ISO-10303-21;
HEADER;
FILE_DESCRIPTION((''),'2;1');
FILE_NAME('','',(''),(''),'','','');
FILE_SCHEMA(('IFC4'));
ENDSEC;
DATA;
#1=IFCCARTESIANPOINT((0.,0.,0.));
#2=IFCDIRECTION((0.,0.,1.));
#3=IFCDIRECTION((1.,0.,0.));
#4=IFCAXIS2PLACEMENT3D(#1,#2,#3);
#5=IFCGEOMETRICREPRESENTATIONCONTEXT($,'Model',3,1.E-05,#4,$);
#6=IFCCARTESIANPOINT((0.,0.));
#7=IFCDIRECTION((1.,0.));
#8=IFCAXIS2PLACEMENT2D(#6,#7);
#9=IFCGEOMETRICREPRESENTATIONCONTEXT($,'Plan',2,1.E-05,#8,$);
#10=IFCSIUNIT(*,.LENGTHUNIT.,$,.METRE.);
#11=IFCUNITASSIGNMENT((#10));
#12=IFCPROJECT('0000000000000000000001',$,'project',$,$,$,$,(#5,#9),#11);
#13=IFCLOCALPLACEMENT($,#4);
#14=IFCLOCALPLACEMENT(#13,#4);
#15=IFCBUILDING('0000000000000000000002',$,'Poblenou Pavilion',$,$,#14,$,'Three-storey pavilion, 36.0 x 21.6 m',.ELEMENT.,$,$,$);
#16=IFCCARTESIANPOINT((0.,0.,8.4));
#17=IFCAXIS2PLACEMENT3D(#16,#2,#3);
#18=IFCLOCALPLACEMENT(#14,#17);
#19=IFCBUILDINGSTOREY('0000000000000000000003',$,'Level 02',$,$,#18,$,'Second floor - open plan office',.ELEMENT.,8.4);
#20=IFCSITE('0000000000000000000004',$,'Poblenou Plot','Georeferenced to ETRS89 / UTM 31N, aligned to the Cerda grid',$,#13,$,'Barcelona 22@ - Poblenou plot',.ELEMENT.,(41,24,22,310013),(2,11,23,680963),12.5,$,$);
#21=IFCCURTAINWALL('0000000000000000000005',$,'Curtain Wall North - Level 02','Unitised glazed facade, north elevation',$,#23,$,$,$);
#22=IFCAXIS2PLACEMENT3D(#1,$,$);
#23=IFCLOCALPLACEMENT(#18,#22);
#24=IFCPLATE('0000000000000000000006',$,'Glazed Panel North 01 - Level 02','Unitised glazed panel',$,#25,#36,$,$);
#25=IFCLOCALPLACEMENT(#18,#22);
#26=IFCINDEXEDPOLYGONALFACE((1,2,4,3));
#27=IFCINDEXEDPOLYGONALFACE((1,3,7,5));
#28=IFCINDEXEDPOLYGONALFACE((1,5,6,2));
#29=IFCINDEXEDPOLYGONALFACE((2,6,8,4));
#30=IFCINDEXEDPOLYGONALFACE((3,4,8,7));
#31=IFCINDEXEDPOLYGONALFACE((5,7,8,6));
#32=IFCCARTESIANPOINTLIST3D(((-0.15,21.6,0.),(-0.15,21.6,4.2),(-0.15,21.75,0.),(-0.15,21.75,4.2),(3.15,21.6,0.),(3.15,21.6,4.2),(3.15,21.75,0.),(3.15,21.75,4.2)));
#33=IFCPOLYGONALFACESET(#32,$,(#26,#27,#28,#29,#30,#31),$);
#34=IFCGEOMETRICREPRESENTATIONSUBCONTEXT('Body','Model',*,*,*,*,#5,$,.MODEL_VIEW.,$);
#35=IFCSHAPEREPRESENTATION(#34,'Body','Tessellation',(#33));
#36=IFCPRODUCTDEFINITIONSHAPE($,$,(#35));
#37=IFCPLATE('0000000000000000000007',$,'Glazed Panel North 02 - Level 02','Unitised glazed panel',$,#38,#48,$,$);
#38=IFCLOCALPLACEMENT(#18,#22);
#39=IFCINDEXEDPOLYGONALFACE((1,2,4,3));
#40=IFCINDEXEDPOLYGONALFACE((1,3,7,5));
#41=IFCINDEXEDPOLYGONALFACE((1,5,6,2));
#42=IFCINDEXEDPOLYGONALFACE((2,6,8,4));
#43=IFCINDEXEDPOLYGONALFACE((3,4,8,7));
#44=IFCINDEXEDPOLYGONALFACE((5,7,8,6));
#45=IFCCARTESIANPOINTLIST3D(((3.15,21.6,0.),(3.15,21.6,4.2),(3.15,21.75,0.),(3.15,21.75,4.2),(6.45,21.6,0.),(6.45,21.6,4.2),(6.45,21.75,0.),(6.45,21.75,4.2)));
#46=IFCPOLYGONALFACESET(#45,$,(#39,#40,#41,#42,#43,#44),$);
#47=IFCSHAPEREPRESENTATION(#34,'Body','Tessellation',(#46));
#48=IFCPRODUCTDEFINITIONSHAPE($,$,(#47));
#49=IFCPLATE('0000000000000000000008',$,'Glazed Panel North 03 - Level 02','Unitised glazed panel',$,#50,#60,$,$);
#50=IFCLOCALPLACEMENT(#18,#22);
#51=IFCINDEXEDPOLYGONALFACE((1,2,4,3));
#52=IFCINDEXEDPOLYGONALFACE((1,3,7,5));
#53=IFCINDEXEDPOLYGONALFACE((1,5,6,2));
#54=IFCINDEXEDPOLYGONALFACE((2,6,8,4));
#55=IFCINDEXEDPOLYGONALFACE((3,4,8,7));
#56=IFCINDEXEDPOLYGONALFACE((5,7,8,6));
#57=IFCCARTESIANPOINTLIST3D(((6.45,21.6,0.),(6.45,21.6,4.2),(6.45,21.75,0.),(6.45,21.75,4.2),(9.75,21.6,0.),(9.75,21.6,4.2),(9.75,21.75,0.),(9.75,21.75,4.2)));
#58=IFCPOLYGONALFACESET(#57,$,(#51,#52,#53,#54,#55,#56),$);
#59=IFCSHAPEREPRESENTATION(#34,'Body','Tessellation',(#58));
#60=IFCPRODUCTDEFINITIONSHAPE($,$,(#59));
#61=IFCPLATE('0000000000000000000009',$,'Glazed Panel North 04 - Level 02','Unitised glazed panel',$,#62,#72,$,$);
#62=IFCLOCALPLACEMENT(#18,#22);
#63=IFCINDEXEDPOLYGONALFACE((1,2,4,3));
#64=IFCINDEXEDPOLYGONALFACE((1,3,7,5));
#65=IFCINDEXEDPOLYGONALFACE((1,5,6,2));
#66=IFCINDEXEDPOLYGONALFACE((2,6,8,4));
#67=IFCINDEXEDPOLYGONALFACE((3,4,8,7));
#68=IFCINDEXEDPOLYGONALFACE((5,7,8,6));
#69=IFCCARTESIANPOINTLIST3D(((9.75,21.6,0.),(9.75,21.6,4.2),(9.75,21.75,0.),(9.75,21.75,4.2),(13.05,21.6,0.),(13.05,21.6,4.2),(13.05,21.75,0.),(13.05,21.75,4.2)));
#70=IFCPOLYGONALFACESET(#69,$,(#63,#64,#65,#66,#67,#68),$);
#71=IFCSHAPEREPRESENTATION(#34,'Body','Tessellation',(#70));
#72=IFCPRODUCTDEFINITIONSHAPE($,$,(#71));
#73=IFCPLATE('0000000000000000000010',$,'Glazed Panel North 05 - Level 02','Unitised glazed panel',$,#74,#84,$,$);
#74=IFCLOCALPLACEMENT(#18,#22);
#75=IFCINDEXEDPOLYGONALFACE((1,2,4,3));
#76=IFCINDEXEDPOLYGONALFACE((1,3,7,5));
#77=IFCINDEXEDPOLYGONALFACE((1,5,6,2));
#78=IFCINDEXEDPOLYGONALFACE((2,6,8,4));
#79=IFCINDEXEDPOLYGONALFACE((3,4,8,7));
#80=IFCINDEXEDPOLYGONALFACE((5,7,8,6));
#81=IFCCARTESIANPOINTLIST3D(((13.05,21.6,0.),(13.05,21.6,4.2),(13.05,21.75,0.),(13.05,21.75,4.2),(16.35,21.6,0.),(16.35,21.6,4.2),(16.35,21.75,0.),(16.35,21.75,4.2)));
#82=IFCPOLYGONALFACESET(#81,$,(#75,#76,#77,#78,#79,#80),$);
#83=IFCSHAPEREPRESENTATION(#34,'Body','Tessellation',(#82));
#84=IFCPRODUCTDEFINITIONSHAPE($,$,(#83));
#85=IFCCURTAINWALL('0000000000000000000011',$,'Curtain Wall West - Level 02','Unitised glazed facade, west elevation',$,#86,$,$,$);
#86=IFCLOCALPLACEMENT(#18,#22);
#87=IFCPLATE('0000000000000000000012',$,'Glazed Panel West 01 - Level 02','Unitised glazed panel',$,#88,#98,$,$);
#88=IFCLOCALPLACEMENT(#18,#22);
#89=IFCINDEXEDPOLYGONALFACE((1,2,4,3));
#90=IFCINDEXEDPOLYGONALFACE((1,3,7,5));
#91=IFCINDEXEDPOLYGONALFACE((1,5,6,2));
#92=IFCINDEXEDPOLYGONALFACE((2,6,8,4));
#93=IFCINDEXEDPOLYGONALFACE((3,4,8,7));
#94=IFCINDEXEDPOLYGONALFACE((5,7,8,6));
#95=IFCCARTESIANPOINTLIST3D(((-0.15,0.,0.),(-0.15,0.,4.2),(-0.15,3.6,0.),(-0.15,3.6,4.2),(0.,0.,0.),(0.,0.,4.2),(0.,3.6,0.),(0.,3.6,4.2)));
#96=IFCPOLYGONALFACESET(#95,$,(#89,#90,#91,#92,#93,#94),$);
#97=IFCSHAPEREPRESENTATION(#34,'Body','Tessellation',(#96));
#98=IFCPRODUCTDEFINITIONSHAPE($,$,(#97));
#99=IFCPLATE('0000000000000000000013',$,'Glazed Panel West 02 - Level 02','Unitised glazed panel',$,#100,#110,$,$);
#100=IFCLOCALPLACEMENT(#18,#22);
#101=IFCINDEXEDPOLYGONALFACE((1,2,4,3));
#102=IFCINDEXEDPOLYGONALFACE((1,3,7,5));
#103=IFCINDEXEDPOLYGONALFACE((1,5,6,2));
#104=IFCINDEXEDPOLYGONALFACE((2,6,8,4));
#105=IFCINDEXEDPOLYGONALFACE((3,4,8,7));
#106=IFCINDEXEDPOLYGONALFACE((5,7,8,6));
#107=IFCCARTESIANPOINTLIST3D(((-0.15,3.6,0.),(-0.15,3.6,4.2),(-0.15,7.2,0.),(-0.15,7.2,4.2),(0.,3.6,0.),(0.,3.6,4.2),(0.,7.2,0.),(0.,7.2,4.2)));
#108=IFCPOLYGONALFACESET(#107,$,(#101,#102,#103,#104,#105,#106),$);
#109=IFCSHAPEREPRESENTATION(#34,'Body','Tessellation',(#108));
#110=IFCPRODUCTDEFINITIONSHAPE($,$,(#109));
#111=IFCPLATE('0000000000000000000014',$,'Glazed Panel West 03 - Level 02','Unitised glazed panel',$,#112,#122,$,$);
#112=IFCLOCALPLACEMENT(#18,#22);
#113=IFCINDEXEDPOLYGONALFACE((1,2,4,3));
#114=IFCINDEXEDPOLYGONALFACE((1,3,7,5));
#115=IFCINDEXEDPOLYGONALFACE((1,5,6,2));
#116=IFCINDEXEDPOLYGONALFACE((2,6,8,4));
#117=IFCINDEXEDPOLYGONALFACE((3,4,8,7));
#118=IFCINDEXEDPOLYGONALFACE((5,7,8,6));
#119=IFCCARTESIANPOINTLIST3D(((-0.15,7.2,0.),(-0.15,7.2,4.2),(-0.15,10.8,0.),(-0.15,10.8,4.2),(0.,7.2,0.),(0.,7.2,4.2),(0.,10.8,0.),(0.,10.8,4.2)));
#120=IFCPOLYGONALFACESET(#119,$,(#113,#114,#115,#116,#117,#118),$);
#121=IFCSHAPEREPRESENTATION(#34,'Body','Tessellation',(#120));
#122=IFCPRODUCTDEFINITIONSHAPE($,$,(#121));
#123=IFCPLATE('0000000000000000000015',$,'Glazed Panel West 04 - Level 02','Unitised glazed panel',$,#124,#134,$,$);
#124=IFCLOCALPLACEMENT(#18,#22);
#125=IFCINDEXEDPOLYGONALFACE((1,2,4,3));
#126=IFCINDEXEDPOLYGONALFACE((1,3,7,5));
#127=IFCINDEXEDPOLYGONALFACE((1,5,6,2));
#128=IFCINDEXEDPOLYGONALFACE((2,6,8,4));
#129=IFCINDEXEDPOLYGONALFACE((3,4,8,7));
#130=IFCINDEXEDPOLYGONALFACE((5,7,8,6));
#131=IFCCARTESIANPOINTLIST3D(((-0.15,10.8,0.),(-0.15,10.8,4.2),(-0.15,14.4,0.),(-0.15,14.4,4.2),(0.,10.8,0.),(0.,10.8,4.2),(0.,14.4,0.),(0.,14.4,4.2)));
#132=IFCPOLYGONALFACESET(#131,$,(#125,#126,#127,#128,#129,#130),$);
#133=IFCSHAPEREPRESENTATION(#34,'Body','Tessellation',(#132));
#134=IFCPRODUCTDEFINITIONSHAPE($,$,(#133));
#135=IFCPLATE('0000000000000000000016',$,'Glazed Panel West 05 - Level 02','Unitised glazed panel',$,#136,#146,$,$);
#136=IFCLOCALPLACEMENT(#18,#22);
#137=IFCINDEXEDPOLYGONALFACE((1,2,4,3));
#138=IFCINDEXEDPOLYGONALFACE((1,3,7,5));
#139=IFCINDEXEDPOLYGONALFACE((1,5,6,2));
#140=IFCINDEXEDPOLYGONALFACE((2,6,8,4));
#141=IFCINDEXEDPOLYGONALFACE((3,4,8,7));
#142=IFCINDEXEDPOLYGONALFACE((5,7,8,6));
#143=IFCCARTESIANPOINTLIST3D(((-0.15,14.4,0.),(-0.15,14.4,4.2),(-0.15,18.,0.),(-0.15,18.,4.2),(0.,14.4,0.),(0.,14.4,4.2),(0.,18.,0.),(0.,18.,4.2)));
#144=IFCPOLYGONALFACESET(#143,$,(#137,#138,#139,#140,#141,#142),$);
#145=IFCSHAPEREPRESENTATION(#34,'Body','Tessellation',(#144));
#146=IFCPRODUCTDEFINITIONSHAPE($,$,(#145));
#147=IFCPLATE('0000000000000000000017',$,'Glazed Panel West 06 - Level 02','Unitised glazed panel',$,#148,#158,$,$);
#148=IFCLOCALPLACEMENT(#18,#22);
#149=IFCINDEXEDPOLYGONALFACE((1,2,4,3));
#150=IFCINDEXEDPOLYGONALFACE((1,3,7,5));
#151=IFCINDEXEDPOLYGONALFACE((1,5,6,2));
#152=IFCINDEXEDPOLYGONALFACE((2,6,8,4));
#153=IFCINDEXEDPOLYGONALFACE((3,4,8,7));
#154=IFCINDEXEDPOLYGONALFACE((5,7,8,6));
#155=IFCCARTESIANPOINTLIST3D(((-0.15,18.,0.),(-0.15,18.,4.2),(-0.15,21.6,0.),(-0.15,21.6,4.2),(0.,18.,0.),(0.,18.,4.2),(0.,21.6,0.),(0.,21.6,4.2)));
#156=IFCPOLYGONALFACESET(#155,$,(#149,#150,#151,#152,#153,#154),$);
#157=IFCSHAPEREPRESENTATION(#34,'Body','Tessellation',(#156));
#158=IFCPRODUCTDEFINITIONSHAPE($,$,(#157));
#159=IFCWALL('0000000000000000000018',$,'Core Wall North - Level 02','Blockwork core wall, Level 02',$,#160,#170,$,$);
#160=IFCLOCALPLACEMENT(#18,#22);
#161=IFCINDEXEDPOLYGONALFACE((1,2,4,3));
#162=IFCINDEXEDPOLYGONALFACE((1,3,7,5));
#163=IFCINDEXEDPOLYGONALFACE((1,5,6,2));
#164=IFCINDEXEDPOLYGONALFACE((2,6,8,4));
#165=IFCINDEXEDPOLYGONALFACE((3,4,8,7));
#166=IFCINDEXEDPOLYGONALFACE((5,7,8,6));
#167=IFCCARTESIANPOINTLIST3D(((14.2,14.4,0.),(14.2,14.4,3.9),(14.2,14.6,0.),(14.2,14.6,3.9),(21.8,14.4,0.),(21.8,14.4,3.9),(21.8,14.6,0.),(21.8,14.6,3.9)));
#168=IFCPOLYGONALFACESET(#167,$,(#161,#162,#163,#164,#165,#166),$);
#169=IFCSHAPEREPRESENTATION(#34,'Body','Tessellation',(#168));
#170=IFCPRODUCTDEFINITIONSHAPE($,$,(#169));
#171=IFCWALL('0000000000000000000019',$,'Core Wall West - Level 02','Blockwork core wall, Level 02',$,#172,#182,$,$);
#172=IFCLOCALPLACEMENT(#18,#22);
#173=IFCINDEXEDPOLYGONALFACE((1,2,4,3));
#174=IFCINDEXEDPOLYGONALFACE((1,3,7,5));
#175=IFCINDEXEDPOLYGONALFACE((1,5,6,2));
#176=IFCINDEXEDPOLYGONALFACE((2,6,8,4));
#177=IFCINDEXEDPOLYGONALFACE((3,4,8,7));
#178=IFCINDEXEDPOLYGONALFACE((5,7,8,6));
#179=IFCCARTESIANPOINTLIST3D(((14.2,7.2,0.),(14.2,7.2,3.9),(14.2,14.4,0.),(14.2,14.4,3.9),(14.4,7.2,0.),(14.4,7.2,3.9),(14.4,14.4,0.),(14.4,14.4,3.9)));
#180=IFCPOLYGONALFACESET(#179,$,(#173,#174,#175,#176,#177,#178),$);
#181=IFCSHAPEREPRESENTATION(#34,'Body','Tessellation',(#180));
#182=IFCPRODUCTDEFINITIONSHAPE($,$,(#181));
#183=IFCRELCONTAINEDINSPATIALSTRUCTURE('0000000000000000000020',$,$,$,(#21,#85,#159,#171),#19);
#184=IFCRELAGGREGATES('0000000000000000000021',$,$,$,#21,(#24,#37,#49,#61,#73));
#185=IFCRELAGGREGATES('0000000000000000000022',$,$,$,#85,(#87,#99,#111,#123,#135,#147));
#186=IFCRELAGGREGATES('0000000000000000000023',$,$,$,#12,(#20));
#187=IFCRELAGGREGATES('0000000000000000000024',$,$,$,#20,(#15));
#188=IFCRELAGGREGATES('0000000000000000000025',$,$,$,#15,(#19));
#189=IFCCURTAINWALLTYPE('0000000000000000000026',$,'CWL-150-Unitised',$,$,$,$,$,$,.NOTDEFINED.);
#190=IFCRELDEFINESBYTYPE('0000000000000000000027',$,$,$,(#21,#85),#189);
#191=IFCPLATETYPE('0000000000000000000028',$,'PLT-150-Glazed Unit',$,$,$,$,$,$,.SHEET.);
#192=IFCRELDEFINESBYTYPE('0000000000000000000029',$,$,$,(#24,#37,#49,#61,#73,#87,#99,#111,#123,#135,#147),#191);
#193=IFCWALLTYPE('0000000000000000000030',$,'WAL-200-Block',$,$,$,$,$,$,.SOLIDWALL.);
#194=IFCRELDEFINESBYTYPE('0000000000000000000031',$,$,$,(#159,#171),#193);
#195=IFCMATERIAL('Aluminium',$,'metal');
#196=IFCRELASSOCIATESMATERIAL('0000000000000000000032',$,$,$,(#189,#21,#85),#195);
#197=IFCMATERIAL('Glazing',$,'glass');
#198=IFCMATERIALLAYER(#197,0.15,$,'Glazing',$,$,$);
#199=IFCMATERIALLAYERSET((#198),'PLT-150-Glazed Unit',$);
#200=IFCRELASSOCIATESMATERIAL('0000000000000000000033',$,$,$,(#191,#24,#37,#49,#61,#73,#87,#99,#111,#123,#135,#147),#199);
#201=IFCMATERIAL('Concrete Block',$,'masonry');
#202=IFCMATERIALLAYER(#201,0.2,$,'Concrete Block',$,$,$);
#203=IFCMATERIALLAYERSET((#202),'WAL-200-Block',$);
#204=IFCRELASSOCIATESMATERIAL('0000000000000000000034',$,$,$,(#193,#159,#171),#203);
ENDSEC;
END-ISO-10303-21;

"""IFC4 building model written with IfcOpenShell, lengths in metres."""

from ifc_helpers import new_model, si_unit, frame, origin_with_axes, origin_2d_with_axis, place, context, subcontext, project, spatial, line, indexed_curve, outline, extrude, material, layer, layer_set, layer_usage, type_object, element, aggregate, save


model = new_model("IFC4")

# Units and contexts
model_context = context("Model", 3, precision=1e-05, world=origin_with_axes())
plan_context = context("Plan", 2, precision=1e-05, world=origin_2d_with_axis())
body_context = subcontext(model_context, "Body", "Model", "MODEL_VIEW")
ifc_project = project(units=[si_unit("LENGTHUNIT", "METRE")], contexts=[model_context, plan_context])

# Site, building, storey
site_placement = place(None, origin_with_axes())
site = spatial("IfcSite", under=ifc_project, at=site_placement, Name="Poblenou Plot", Description="Georeferenced to ETRS89 / UTM 31N, aligned to the Cerda grid", LongName="Barcelona 22@ - Poblenou plot", CompositionType="ELEMENT", RefLatitude=(41, 24, 22, 310013), RefLongitude=(2, 11, 23, 680963), RefElevation=12.5)
building_placement = place(site_placement, origin_with_axes())
building = spatial("IfcBuilding", under=site, at=building_placement, Name="Poblenou Pavilion", LongName="Three-storey pavilion, 36.0 x 21.6 m", CompositionType="ELEMENT")
storey_placement = place(building_placement, frame((0.0, 0.0, 8.4), z_axis=(0.0, 0.0, 1.0), x_axis=(1.0, 0.0, 0.0)))
storey = spatial("IfcBuildingStorey", under=building, at=storey_placement, Name="Level 02", LongName="Second floor - open plan office", CompositionType="ELEMENT", Elevation=8.4)

# Curtain walls, plates
ifc_material_1 = material(Name="Aluminium", Category="metal")
curtain_wall_type = type_object("IfcCurtainWallType", Name="CWL-150-Unitised", PredefinedType="NOTDEFINED", material=ifc_material_1)
ifc_material_2 = material(Name="Glazing", Category="glass")
ifc_layer_1 = layer(ifc_material_2, 0.15, Name="Glazing")
ifc_layer_set_1 = layer_set([ifc_layer_1], Name="PLT-150-Glazed Unit")
plate_type = type_object("IfcPlateType", Name="PLT-150-Glazed Unit", PredefinedType="SHEET", material=ifc_layer_set_1)
curtain_wall_1_placement = place(storey_placement, frame((-0.15, 21.6, 0.0), z_axis=(0.0, 0.0, 1.0), x_axis=(1.0, 0.0, 0.0)))
curtain_wall_1 = element("IfcCurtainWall", 1, at=curtain_wall_1_placement, inside=storey, type_object=curtain_wall_type, material=ifc_material_1, Name="Curtain Wall North - Level 02", Description="Unitised glazed facade, north elevation")
ifc_layer_usage_1 = layer_usage(ifc_layer_set_1, "AXIS2", "POSITIVE", 0.0)
plate_1_placement = place(curtain_wall_1_placement, origin_with_axes())
plate_1 = element("IfcPlate", 2, at=plate_1_placement, type_object=plate_type, material=ifc_layer_usage_1, Name="Glazed Panel North 01 - Level 02", Description="Unitised glazed panel", context=body_context, shape_type="SweptSolid", body=[
    extrude(outline(indexed_curve([(0.0, 0.0), (3.3, 0.0), (3.3, 0.15), (0.0, 0.15)], segments=[line(1, 2, 3, 4, 1)])), origin_with_axes(), (0.0, 0.0, 1.0), 4.2),
])
ifc_layer_usage_2 = layer_usage(ifc_layer_set_1, "AXIS2", "POSITIVE", 0.0)
plate_2_placement = place(curtain_wall_1_placement, frame((3.3, 0.0, 0.0), z_axis=(0.0, 0.0, 1.0), x_axis=(1.0, 0.0, 0.0)))
plate_2 = element("IfcPlate", 3, at=plate_2_placement, type_object=plate_type, material=ifc_layer_usage_2, Name="Glazed Panel North 02 - Level 02", Description="Unitised glazed panel", context=body_context, shape_type="SweptSolid", body=[
    extrude(outline(indexed_curve([(0.0, 0.0), (3.3, 0.0), (3.3, 0.15), (0.0, 0.15)], segments=[line(1, 2, 3, 4, 1)])), origin_with_axes(), (0.0, 0.0, 1.0), 4.2),
])
ifc_layer_usage_3 = layer_usage(ifc_layer_set_1, "AXIS2", "POSITIVE", 0.0)
plate_3_placement = place(curtain_wall_1_placement, frame((6.6, 0.0, 0.0), z_axis=(0.0, 0.0, 1.0), x_axis=(1.0, 0.0, 0.0)))
plate_3 = element("IfcPlate", 4, at=plate_3_placement, type_object=plate_type, material=ifc_layer_usage_3, Name="Glazed Panel North 03 - Level 02", Description="Unitised glazed panel", context=body_context, shape_type="SweptSolid", body=[
    extrude(outline(indexed_curve([(0.0, 0.0), (3.3, 0.0), (3.3, 0.15), (0.0, 0.15)], segments=[line(1, 2, 3, 4, 1)])), origin_with_axes(), (0.0, 0.0, 1.0), 4.2),
])
ifc_layer_usage_4 = layer_usage(ifc_layer_set_1, "AXIS2", "POSITIVE", 0.0)
plate_4_placement = place(curtain_wall_1_placement, frame((9.9, 0.0, 0.0), z_axis=(0.0, 0.0, 1.0), x_axis=(1.0, 0.0, 0.0)))
plate_4 = element("IfcPlate", 5, at=plate_4_placement, type_object=plate_type, material=ifc_layer_usage_4, Name="Glazed Panel North 04 - Level 02", Description="Unitised glazed panel", context=body_context, shape_type="SweptSolid", body=[
    extrude(outline(indexed_curve([(0.0, 0.0), (3.3, 0.0), (3.3, 0.15), (0.0, 0.15)], segments=[line(1, 2, 3, 4, 1)])), origin_with_axes(), (0.0, 0.0, 1.0), 4.2),
])
ifc_layer_usage_5 = layer_usage(ifc_layer_set_1, "AXIS2", "POSITIVE", 0.0)
plate_5_placement = place(curtain_wall_1_placement, frame((13.2, 0.0, 0.0), z_axis=(0.0, 0.0, 1.0), x_axis=(1.0, 0.0, 0.0)))
plate_5 = element("IfcPlate", 6, at=plate_5_placement, type_object=plate_type, material=ifc_layer_usage_5, Name="Glazed Panel North 05 - Level 02", Description="Unitised glazed panel", context=body_context, shape_type="SweptSolid", body=[
    extrude(outline(indexed_curve([(0.0, 0.0), (3.3, 0.0), (3.3, 0.15), (0.0, 0.15)], segments=[line(1, 2, 3, 4, 1)])), origin_with_axes(), (0.0, 0.0, 1.0), 4.2),
])
aggregate(curtain_wall_1, [plate_1, plate_2, plate_3, plate_4, plate_5])
curtain_wall_2_placement = place(storey_placement, frame((0.0, 0.0, 0.0), z_axis=(0.0, 0.0, 1.0), x_axis=(0.0, 1.0, 0.0)))
curtain_wall_2 = element("IfcCurtainWall", 7, at=curtain_wall_2_placement, inside=storey, type_object=curtain_wall_type, material=ifc_material_1, Name="Curtain Wall West - Level 02", Description="Unitised glazed facade, west elevation")
ifc_layer_usage_6 = layer_usage(ifc_layer_set_1, "AXIS2", "POSITIVE", 0.0)
plate_6_placement = place(curtain_wall_2_placement, origin_with_axes())
plate_6 = element("IfcPlate", 8, at=plate_6_placement, type_object=plate_type, material=ifc_layer_usage_6, Name="Glazed Panel West 01 - Level 02", Description="Unitised glazed panel", context=body_context, shape_type="SweptSolid", body=[
    extrude(outline(indexed_curve([(0.0, 0.0), (3.6, 0.0), (3.6, 0.15), (0.0, 0.15)], segments=[line(1, 2, 3, 4, 1)])), origin_with_axes(), (0.0, 0.0, 1.0), 4.2),
])
ifc_layer_usage_7 = layer_usage(ifc_layer_set_1, "AXIS2", "POSITIVE", 0.0)
plate_7_placement = place(curtain_wall_2_placement, frame((3.6, 0.0, 0.0), z_axis=(0.0, 0.0, 1.0), x_axis=(1.0, 0.0, 0.0)))
plate_7 = element("IfcPlate", 9, at=plate_7_placement, type_object=plate_type, material=ifc_layer_usage_7, Name="Glazed Panel West 02 - Level 02", Description="Unitised glazed panel", context=body_context, shape_type="SweptSolid", body=[
    extrude(outline(indexed_curve([(0.0, 0.0), (3.6, 0.0), (3.6, 0.15), (0.0, 0.15)], segments=[line(1, 2, 3, 4, 1)])), origin_with_axes(), (0.0, 0.0, 1.0), 4.2),
])
ifc_layer_usage_8 = layer_usage(ifc_layer_set_1, "AXIS2", "POSITIVE", 0.0)
plate_8_placement = place(curtain_wall_2_placement, frame((7.2, 0.0, 0.0), z_axis=(0.0, 0.0, 1.0), x_axis=(1.0, 0.0, 0.0)))
plate_8 = element("IfcPlate", 10, at=plate_8_placement, type_object=plate_type, material=ifc_layer_usage_8, Name="Glazed Panel West 03 - Level 02", Description="Unitised glazed panel", context=body_context, shape_type="SweptSolid", body=[
    extrude(outline(indexed_curve([(0.0, 0.0), (3.6, 0.0), (3.6, 0.15), (0.0, 0.15)], segments=[line(1, 2, 3, 4, 1)])), origin_with_axes(), (0.0, 0.0, 1.0), 4.2),
])
ifc_layer_usage_9 = layer_usage(ifc_layer_set_1, "AXIS2", "POSITIVE", 0.0)
plate_9_placement = place(curtain_wall_2_placement, frame((10.8, 0.0, 0.0), z_axis=(0.0, 0.0, 1.0), x_axis=(1.0, 0.0, 0.0)))
plate_9 = element("IfcPlate", 11, at=plate_9_placement, type_object=plate_type, material=ifc_layer_usage_9, Name="Glazed Panel West 04 - Level 02", Description="Unitised glazed panel", context=body_context, shape_type="SweptSolid", body=[
    extrude(outline(indexed_curve([(0.0, 0.0), (3.6, 0.0), (3.6, 0.15), (0.0, 0.15)], segments=[line(1, 2, 3, 4, 1)])), origin_with_axes(), (0.0, 0.0, 1.0), 4.2),
])
ifc_layer_usage_10 = layer_usage(ifc_layer_set_1, "AXIS2", "POSITIVE", 0.0)
plate_10_placement = place(curtain_wall_2_placement, frame((14.4, 0.0, 0.0), z_axis=(0.0, 0.0, 1.0), x_axis=(1.0, 0.0, 0.0)))
plate_10 = element("IfcPlate", 12, at=plate_10_placement, type_object=plate_type, material=ifc_layer_usage_10, Name="Glazed Panel West 05 - Level 02", Description="Unitised glazed panel", context=body_context, shape_type="SweptSolid", body=[
    extrude(outline(indexed_curve([(0.0, 0.0), (3.6, 0.0), (3.6, 0.15), (0.0, 0.15)], segments=[line(1, 2, 3, 4, 1)])), origin_with_axes(), (0.0, 0.0, 1.0), 4.2),
])
ifc_layer_usage_11 = layer_usage(ifc_layer_set_1, "AXIS2", "POSITIVE", 0.0)
plate_11_placement = place(curtain_wall_2_placement, frame((18.0, 0.0, 0.0), z_axis=(0.0, 0.0, 1.0), x_axis=(1.0, 0.0, 0.0)))
plate_11 = element("IfcPlate", 13, at=plate_11_placement, type_object=plate_type, material=ifc_layer_usage_11, Name="Glazed Panel West 06 - Level 02", Description="Unitised glazed panel", context=body_context, shape_type="SweptSolid", body=[
    extrude(outline(indexed_curve([(0.0, 0.0), (3.6, 0.0), (3.6, 0.15), (0.0, 0.15)], segments=[line(1, 2, 3, 4, 1)])), origin_with_axes(), (0.0, 0.0, 1.0), 4.2),
])
aggregate(curtain_wall_2, [plate_6, plate_7, plate_8, plate_9, plate_10, plate_11])

# Walls
ifc_material_3 = material(Name="Concrete Block", Category="masonry")
ifc_layer_2 = layer(ifc_material_3, 0.2, Name="Concrete Block")
ifc_layer_set_2 = layer_set([ifc_layer_2], Name="WAL-200-Block")
ifc_layer_usage_12 = layer_usage(ifc_layer_set_2, "AXIS2", "POSITIVE", 0.0)
wall_type = type_object("IfcWallType", Name="WAL-200-Block", PredefinedType="SOLIDWALL", material=ifc_layer_set_2)
wall_1_placement = place(storey_placement, frame((14.2, 14.4, 0.0), z_axis=(0.0, 0.0, 1.0), x_axis=(1.0, 0.0, 0.0)))
element("IfcWall", 14, at=wall_1_placement, inside=storey, type_object=wall_type, material=ifc_layer_usage_12, Name="Core Wall North - Level 02", Description="Blockwork core wall, Level 02", context=body_context, shape_type="SweptSolid", body=[
    extrude(outline(indexed_curve([(0.0, 0.0), (7.6, 0.0), (7.6, 0.2), (0.0, 0.2)], segments=[line(1, 2, 3, 4, 1)])), origin_with_axes(), (0.0, 0.0, 1.0), 3.9),
])
ifc_layer_usage_13 = layer_usage(ifc_layer_set_2, "AXIS2", "POSITIVE", 0.0)
wall_2_placement = place(storey_placement, frame((14.4, 7.2, 0.0), z_axis=(0.0, 0.0, 1.0), x_axis=(0.0, 1.0, 0.0)))
element("IfcWall", 15, at=wall_2_placement, inside=storey, type_object=wall_type, material=ifc_layer_usage_13, Name="Core Wall West - Level 02", Description="Blockwork core wall, Level 02", context=body_context, shape_type="SweptSolid", body=[
    extrude(outline(indexed_curve([(0.0, 0.0), (7.2, 0.0), (7.2, 0.2), (0.0, 0.2)], segments=[line(1, 2, 3, 4, 1)])), origin_with_axes(), (0.0, 0.0, 1.0), 3.9),
])

save(model, "model.ifc")
